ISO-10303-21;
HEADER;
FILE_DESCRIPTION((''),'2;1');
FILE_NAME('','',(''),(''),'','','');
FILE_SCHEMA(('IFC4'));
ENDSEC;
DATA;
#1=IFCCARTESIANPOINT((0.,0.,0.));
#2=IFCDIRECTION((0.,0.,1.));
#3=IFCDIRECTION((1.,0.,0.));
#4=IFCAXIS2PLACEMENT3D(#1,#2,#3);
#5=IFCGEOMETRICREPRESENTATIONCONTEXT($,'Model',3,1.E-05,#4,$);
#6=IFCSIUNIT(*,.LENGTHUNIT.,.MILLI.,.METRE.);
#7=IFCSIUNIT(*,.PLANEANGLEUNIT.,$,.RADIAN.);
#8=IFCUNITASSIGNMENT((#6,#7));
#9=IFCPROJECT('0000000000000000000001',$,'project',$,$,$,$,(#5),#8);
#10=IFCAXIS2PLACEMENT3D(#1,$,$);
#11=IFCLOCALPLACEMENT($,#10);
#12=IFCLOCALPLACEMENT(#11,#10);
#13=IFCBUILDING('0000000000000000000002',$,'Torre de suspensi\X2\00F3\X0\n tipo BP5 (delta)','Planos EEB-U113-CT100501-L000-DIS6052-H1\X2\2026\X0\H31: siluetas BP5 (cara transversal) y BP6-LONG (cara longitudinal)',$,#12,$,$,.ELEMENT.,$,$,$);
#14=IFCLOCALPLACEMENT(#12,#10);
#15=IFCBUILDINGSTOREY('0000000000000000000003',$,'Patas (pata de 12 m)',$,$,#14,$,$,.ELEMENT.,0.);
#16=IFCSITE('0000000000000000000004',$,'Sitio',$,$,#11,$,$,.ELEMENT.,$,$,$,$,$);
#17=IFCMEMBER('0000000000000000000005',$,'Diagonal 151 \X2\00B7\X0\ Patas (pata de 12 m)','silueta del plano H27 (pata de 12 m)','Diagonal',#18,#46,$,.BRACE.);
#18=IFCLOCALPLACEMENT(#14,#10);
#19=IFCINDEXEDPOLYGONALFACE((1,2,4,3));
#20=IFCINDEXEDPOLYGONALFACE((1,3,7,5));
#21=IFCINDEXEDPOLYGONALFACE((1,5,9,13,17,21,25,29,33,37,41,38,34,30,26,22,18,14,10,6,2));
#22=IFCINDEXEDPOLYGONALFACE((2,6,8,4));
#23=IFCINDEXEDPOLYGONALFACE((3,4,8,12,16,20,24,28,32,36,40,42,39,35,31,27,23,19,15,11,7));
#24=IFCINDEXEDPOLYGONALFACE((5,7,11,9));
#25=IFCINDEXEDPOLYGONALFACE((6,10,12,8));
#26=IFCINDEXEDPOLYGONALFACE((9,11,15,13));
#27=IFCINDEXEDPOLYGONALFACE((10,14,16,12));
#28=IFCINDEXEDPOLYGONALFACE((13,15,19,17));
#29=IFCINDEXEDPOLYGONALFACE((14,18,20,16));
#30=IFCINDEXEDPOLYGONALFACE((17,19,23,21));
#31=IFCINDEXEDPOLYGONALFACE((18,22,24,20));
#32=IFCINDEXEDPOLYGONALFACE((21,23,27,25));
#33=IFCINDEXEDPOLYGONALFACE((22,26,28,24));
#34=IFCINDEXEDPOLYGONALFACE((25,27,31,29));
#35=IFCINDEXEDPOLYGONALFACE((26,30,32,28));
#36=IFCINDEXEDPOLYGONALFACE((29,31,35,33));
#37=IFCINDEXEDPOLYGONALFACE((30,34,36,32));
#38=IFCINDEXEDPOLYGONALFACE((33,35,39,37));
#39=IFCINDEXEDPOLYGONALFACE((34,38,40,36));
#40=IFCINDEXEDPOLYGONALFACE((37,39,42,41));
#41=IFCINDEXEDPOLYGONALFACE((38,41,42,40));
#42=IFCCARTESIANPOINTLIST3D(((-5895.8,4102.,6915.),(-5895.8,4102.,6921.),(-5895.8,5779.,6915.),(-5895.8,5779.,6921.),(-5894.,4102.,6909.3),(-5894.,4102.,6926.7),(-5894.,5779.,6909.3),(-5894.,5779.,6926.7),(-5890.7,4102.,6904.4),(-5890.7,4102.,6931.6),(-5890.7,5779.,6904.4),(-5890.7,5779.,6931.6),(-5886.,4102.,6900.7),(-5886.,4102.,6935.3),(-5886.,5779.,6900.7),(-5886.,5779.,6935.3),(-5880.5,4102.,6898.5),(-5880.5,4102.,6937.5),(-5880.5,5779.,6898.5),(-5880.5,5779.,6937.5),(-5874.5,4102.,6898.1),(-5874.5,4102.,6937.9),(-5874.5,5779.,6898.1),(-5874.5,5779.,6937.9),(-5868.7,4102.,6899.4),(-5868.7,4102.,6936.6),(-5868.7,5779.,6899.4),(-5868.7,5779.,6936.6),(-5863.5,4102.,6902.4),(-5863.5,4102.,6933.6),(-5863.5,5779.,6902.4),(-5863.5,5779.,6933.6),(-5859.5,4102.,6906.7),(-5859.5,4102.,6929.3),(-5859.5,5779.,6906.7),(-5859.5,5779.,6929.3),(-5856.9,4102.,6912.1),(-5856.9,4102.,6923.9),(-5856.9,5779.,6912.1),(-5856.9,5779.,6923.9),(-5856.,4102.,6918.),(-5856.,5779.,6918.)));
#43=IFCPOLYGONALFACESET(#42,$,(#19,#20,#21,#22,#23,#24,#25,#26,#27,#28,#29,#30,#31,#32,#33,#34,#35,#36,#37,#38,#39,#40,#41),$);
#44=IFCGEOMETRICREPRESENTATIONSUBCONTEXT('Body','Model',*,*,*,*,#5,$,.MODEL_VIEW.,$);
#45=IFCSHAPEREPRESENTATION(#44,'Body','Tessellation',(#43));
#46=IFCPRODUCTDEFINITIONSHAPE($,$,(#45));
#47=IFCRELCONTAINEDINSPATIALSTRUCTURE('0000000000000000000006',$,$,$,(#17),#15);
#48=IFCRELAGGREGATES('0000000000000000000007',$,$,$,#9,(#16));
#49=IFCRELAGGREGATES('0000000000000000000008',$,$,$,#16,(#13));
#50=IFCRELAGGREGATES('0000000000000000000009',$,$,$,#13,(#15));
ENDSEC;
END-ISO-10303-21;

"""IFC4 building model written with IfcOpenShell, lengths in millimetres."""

from ifc_helpers import new_model, si_unit, frame, origin, origin_with_axes, place, context, subcontext, project, spatial, circle, extrude, element, save


model = new_model("IFC4")

# Units and contexts
model_context = context("Model", 3, precision=1e-05, world=origin_with_axes())
body_context = subcontext(model_context, "Body", "Model", "MODEL_VIEW")
ifc_project = project(units=[si_unit("LENGTHUNIT", "METRE", prefix="MILLI"), si_unit("PLANEANGLEUNIT", "RADIAN")], contexts=[model_context])

# Site, building, storey
site_placement = place(None, origin())
site = spatial("IfcSite", under=ifc_project, at=site_placement, Name="Sitio", CompositionType="ELEMENT")
building_placement = place(site_placement, origin())
building = spatial("IfcBuilding", under=site, at=building_placement, Name="Torre de suspensión tipo BP5 (delta)", Description="Planos EEB-U113-CT100501-L000-DIS6052-H1…H31: siluetas BP5 (cara transversal) y BP6-LONG (cara longitudinal)", CompositionType="ELEMENT")
storey_placement = place(building_placement, origin())
storey = spatial("IfcBuildingStorey", under=building, at=storey_placement, Name="Patas (pata de 12 m)", CompositionType="ELEMENT", Elevation=0.0)

# Member
member_1_placement = place(storey_placement, frame((-5876.0, 5779.0, 6918.0), z_axis=(0.0, -1.0, 0.0), x_axis=(1.0, 0.0, 0.0)))
element("IfcMember", 1, at=member_1_placement, inside=storey, Name="Diagonal 151 · Patas (pata de 12 m)", Description="silueta del plano H27 (pata de 12 m)", ObjectType="Diagonal", PredefinedType="BRACE", context=body_context, shape_type="SweptSolid", body=[
    extrude(circle(Radius=20.0), None, (0.0, 0.0, 1.0), 1677.0),
])

save(model, "model.ifc")
